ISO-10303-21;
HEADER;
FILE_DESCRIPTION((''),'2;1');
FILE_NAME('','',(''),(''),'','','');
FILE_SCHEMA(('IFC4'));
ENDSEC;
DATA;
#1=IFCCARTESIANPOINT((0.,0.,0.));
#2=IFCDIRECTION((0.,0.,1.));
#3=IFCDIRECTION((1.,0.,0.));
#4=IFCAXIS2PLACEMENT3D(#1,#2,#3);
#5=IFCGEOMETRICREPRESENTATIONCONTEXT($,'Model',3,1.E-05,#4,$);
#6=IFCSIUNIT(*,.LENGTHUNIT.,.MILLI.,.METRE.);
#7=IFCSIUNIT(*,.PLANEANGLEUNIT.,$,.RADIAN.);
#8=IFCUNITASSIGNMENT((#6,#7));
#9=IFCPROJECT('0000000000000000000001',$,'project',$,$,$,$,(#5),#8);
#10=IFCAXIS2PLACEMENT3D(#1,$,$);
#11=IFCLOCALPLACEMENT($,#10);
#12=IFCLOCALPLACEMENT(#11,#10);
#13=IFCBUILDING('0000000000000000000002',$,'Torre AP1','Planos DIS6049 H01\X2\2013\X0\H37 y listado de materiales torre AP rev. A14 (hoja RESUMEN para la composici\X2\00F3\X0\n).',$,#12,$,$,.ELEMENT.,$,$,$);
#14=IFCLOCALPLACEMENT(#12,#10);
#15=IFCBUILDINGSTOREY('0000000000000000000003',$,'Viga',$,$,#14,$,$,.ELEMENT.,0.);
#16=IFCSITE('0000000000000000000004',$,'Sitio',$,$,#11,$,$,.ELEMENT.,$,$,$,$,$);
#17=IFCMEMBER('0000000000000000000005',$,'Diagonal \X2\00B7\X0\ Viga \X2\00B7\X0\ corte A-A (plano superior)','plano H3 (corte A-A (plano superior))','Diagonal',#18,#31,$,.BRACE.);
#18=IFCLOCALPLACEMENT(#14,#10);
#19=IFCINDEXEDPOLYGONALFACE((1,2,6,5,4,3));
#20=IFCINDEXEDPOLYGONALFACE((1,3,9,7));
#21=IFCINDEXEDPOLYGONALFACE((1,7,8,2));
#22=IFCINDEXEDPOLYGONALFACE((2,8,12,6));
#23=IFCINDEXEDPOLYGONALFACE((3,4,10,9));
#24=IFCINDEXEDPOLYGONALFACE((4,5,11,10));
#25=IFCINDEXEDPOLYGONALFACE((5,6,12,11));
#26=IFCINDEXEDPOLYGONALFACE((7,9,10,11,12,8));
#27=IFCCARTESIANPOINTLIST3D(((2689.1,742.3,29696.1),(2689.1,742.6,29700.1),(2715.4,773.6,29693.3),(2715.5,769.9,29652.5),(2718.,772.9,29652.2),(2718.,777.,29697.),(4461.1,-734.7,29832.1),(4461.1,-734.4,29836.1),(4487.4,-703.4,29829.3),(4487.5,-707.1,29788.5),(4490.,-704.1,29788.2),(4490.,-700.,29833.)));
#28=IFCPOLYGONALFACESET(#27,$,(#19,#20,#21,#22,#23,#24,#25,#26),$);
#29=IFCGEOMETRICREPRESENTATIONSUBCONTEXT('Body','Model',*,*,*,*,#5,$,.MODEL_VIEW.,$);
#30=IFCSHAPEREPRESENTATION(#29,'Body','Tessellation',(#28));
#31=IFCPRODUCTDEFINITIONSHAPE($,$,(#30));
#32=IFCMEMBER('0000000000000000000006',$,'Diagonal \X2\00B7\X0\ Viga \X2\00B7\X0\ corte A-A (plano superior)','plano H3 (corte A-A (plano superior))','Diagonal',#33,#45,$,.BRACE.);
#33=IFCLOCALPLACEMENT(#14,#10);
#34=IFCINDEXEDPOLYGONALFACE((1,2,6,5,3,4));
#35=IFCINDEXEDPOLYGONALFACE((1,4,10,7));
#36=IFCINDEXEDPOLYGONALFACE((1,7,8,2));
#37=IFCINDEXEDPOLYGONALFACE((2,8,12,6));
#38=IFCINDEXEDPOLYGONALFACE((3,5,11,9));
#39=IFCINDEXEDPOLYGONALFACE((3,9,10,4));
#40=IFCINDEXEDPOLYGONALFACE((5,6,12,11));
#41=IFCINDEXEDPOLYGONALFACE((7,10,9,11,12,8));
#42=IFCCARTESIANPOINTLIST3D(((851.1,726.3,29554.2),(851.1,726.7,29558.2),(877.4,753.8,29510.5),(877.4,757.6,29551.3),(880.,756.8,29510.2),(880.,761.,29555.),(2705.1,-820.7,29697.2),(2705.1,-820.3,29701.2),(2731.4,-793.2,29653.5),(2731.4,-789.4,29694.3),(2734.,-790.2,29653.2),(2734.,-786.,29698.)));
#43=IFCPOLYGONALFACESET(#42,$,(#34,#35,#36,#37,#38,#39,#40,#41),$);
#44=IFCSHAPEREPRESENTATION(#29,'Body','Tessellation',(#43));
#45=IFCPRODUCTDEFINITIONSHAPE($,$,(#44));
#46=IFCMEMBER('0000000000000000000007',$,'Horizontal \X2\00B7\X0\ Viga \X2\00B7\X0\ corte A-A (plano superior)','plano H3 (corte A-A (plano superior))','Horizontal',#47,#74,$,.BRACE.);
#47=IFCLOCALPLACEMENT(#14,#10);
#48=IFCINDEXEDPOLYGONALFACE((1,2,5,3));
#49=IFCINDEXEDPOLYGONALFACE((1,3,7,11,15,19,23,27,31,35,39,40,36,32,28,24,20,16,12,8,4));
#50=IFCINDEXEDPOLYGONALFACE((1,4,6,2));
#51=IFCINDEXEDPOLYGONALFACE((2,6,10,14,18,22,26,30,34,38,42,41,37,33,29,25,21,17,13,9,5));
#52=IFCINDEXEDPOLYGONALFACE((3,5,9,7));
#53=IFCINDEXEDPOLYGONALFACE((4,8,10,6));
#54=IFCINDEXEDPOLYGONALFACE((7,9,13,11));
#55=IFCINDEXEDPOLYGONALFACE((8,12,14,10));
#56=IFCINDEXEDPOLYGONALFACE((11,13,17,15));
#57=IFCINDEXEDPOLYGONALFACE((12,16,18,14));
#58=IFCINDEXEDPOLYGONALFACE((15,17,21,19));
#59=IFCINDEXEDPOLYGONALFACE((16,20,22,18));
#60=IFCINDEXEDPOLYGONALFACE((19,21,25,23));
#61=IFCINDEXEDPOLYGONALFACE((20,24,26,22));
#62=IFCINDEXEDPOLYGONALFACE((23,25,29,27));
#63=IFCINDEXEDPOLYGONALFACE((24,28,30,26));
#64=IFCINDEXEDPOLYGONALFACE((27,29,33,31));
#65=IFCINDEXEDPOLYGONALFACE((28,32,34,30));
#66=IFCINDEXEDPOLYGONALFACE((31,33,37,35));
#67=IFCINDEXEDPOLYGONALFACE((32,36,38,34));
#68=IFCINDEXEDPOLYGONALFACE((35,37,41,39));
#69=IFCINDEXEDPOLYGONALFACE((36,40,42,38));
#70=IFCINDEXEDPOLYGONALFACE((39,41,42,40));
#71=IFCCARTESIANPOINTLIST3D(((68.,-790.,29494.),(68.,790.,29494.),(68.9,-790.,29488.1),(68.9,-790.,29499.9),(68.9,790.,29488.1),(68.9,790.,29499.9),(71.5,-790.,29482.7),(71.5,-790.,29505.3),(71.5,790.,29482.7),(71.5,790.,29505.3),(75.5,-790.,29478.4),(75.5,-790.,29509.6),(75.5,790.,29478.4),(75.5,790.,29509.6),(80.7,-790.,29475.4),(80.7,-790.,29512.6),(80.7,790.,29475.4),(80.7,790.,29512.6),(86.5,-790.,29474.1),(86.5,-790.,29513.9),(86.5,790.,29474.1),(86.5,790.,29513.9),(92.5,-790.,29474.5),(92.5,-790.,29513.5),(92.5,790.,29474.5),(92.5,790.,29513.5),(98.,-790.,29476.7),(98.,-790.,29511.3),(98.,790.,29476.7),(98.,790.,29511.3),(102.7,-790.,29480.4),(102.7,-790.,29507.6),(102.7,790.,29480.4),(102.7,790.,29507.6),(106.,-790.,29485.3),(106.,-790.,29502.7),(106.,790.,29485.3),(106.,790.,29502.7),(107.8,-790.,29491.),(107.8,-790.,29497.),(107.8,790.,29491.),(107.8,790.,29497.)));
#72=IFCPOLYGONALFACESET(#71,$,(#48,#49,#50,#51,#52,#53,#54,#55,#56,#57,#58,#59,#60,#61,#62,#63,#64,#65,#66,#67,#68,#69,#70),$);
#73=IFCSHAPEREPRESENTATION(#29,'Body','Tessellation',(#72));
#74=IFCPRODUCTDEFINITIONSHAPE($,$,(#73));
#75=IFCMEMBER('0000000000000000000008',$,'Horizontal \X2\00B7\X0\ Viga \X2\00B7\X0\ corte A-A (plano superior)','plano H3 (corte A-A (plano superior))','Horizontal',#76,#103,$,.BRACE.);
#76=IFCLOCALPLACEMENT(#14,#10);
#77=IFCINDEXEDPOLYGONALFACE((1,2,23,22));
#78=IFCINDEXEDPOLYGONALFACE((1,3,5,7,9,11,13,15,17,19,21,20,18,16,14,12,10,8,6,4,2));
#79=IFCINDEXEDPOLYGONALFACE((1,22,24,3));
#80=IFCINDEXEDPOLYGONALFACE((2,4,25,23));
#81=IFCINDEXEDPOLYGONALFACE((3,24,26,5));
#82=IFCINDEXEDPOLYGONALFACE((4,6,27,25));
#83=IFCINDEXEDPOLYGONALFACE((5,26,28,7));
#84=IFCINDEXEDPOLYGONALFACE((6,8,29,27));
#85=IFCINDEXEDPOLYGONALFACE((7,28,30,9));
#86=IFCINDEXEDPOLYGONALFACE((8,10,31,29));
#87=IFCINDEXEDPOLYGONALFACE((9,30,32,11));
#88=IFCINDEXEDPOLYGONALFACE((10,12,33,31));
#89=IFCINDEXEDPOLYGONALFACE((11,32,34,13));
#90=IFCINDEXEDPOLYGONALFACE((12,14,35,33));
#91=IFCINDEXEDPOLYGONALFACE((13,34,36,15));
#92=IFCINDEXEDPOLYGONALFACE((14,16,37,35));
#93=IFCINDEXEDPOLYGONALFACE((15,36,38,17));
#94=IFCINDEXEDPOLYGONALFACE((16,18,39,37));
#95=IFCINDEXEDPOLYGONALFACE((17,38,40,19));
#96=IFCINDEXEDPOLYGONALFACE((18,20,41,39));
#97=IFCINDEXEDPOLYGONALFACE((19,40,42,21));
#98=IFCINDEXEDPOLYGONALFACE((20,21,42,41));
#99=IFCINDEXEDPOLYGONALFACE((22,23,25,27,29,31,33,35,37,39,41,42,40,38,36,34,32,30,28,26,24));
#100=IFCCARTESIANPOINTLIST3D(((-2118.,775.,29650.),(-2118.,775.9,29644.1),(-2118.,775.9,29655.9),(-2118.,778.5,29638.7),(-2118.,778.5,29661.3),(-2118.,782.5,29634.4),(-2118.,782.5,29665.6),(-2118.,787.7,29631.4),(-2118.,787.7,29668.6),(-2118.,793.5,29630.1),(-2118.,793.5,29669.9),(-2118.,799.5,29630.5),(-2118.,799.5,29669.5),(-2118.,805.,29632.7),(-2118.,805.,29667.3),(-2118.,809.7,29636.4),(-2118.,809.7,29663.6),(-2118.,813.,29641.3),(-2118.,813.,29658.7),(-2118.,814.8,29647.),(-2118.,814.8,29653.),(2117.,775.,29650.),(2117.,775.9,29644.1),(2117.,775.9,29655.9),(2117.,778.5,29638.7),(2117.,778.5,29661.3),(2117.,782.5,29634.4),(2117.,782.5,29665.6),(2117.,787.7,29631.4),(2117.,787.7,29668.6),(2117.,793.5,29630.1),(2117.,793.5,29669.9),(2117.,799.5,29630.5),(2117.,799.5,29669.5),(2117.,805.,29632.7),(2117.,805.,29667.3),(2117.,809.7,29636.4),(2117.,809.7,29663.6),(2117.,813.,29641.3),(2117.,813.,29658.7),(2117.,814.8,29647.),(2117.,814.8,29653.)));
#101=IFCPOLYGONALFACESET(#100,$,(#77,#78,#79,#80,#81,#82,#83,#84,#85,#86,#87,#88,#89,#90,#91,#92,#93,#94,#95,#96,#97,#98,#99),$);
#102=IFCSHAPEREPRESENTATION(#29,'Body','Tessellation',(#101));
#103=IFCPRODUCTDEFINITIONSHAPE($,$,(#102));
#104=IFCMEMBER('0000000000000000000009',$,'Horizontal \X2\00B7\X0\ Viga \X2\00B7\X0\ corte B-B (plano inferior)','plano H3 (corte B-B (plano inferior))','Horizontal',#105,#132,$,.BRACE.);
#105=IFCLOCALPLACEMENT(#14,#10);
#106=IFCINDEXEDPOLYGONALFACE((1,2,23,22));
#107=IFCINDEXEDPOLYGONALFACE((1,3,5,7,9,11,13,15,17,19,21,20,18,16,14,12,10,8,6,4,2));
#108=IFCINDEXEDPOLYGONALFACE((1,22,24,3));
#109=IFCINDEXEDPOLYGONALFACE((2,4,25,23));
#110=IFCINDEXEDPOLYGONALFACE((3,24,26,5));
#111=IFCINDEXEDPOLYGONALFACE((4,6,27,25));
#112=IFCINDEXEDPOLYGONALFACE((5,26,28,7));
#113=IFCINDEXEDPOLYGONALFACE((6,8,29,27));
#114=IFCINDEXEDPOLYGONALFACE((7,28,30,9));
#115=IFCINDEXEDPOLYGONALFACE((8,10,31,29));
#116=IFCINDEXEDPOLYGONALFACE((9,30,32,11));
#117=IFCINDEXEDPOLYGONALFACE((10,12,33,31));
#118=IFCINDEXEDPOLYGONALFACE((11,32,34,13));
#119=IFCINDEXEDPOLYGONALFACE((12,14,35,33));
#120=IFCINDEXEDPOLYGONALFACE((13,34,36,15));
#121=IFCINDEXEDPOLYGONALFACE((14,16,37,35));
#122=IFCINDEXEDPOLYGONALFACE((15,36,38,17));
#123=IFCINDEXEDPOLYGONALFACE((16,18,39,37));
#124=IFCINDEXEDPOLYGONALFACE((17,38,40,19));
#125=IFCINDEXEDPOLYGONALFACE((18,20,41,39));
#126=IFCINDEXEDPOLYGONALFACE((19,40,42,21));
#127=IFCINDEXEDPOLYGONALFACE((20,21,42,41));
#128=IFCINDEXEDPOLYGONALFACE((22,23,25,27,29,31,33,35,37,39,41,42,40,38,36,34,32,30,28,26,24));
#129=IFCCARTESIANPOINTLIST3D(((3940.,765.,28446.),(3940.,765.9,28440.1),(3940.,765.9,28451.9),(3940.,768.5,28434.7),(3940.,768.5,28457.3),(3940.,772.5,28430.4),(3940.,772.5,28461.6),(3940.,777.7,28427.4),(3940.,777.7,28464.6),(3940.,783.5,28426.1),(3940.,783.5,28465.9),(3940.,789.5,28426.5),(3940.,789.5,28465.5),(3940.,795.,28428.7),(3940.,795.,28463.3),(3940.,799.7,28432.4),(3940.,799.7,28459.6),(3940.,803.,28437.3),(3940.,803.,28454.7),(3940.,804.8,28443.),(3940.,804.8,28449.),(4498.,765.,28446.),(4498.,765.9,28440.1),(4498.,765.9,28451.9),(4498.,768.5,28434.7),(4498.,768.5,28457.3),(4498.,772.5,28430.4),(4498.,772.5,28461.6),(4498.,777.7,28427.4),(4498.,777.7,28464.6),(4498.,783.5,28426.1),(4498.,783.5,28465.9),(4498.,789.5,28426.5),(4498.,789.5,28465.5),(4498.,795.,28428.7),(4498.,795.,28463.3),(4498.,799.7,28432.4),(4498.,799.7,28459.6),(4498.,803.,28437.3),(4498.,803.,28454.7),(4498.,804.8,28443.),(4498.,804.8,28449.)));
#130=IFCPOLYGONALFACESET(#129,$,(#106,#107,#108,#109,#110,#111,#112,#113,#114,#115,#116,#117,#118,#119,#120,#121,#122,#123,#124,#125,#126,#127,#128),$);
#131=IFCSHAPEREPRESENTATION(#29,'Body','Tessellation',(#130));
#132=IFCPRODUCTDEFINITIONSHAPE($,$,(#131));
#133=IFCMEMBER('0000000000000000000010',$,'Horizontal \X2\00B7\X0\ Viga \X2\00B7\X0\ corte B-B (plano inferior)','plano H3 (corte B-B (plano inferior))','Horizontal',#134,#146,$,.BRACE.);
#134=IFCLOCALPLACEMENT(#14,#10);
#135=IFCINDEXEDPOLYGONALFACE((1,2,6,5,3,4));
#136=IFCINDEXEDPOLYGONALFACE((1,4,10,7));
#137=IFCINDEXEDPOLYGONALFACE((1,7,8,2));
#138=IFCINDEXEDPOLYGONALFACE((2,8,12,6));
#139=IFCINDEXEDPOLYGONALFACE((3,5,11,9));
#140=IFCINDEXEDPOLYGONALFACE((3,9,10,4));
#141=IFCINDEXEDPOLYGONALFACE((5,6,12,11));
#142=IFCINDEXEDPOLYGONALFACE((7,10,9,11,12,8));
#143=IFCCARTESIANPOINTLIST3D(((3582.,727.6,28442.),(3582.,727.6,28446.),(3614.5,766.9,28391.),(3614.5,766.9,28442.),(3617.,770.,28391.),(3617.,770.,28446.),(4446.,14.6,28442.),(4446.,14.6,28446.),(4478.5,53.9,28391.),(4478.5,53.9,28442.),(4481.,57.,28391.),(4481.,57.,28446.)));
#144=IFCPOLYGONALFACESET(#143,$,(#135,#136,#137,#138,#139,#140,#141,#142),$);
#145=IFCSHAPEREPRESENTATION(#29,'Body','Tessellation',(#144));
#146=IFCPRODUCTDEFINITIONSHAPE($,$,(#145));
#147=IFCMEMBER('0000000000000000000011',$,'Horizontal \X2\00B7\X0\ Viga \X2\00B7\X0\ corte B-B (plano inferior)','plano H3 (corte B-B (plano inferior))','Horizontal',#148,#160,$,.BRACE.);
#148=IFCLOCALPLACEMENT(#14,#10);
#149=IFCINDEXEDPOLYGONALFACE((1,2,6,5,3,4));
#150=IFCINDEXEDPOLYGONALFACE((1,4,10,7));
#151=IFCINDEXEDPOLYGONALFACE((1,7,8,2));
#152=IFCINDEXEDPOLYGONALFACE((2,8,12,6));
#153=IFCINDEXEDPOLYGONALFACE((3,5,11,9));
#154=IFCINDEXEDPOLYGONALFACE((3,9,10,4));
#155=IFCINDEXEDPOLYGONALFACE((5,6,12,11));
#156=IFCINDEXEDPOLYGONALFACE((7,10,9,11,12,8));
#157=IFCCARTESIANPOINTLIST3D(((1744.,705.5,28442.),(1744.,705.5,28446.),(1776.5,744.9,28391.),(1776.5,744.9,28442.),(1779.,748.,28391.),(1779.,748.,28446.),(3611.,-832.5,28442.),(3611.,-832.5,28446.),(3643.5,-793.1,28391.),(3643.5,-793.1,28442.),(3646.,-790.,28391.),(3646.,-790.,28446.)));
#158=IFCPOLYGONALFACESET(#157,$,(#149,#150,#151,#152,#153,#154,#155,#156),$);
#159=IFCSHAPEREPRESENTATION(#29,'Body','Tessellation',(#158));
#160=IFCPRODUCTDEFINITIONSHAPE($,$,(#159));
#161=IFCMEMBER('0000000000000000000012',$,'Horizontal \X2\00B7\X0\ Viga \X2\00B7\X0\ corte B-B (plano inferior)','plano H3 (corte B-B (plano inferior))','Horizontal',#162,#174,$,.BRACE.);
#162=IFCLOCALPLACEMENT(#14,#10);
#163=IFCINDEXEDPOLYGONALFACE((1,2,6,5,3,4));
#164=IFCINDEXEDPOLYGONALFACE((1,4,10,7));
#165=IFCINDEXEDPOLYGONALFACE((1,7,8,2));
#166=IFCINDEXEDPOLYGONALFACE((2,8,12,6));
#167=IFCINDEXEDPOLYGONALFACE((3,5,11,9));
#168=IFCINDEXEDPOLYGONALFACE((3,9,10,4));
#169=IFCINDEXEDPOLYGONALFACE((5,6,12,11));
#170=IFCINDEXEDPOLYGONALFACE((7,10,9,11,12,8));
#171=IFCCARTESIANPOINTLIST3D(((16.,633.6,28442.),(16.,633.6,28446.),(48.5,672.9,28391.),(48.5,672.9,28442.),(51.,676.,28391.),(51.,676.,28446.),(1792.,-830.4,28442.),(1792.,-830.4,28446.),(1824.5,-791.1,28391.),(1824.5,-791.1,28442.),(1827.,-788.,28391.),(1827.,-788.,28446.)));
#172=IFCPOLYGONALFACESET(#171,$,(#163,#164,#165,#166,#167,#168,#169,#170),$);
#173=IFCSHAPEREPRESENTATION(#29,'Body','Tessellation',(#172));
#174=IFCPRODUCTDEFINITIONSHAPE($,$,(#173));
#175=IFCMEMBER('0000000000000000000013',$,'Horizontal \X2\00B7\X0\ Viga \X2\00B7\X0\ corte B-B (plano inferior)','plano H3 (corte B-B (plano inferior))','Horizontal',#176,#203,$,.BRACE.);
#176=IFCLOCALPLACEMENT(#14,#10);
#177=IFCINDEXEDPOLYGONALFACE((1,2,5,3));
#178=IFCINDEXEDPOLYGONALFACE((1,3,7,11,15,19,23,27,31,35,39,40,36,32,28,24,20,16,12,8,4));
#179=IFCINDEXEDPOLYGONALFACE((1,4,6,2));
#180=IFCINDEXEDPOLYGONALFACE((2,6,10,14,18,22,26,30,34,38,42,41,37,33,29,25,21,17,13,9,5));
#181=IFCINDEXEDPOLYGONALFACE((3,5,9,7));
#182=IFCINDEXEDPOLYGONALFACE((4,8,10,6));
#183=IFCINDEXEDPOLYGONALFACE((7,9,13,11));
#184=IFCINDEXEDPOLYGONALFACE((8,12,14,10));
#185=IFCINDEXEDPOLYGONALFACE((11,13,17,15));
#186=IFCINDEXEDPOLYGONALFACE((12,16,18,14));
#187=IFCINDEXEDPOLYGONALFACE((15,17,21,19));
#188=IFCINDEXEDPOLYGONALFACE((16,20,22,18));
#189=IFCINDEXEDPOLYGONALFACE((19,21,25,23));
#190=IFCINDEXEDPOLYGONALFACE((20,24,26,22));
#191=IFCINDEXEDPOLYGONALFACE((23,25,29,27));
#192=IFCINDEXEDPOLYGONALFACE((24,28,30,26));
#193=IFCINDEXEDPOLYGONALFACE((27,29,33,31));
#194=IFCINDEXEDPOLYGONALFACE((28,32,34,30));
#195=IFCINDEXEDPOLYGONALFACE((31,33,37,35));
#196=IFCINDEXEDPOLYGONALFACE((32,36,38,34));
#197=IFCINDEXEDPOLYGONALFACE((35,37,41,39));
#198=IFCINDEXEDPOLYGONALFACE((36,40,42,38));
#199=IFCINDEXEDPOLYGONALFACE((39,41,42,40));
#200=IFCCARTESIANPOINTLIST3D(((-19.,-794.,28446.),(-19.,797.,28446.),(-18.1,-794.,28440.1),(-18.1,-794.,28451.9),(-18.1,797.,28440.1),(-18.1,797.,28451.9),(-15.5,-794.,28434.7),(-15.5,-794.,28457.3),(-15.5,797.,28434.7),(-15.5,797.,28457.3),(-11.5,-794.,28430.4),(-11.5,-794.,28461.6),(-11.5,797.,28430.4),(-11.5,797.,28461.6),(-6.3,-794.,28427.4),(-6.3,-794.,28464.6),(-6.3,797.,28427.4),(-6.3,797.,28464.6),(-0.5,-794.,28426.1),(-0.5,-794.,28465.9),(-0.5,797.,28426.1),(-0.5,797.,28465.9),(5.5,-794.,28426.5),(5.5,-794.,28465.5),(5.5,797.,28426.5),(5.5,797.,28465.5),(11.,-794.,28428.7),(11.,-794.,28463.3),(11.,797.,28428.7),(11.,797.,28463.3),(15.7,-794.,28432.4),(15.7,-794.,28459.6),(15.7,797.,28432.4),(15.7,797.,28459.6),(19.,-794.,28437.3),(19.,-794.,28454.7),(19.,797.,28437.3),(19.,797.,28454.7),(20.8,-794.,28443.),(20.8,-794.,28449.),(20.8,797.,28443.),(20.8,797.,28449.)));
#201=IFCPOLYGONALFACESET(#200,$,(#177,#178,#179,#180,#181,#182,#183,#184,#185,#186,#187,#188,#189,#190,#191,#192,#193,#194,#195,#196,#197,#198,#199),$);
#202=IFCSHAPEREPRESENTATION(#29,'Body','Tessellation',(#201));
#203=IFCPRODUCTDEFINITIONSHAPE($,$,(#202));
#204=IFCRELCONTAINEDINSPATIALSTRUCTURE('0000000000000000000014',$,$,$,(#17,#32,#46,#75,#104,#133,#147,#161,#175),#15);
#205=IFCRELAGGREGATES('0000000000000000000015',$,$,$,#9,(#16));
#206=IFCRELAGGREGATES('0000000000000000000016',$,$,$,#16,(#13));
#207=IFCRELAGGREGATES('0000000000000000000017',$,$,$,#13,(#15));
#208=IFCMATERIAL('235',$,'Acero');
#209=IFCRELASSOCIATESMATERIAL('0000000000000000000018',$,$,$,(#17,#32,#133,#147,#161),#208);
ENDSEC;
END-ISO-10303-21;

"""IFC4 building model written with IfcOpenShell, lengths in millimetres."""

from ifc_helpers import new_model, si_unit, frame, frame_2d, origin, origin_with_axes, place, context, subcontext, project, spatial, circle, l_section, extrude, material, element, save


model = new_model("IFC4")

# Units and contexts
model_context = context("Model", 3, precision=1e-05, world=origin_with_axes())
body_context = subcontext(model_context, "Body", "Model", "MODEL_VIEW")
ifc_project = project(units=[si_unit("LENGTHUNIT", "METRE", prefix="MILLI"), si_unit("PLANEANGLEUNIT", "RADIAN")], contexts=[model_context])

# Site, building, storey
site_placement = place(None, origin())
site = spatial("IfcSite", under=ifc_project, at=site_placement, Name="Sitio", CompositionType="ELEMENT")
building_placement = place(site_placement, origin())
building = spatial("IfcBuilding", under=site, at=building_placement, Name="Torre AP1", Description="Planos DIS6049 H01–H37 y listado de materiales torre AP rev. A14 (hoja RESUMEN para la composición).", CompositionType="ELEMENT")
storey_placement = place(building_placement, origin())
storey = spatial("IfcBuildingStorey", under=building, at=storey_placement, Name="Viga", CompositionType="ELEMENT", Elevation=0.0)

# Members
ifc_material = material(Name="235", Category="Acero")
member_1_placement = place(storey_placement, frame((2718.0, 777.0, 29697.0), z_axis=(0.766819, -0.63916, 0.058853), x_axis=(-0.641863, -0.763726, 0.06881)))
element("IfcMember", 1, at=member_1_placement, inside=storey, material=ifc_material, Name="Diagonal · Viga · corte A-A (plano superior)", Description="plano H3 (corte A-A (plano superior))", ObjectType="Diagonal", PredefinedType="BRACE", context=body_context, shape_type="SweptSolid", body=[
    extrude(l_section(Depth=45.0, Width=45.0, Thickness=4.0, at=frame_2d((22.5, 22.5))), None, (0.0, 0.0, 1.0), 2310.8),
])
member_2_placement = place(storey_placement, frame((880.0, 761.0, 29555.0), z_axis=(0.766471, -0.639553, 0.059118), x_axis=(-0.642279, -0.763125, 0.071545)))
element("IfcMember", 2, at=member_2_placement, inside=storey, material=ifc_material, Name="Diagonal · Viga · corte A-A (plano superior)", Description="plano H3 (corte A-A (plano superior))", ObjectType="Diagonal", PredefinedType="BRACE", context=body_context, shape_type="SweptSolid", body=[
    extrude(l_section(Depth=45.0, Width=45.0, Thickness=4.0, at=frame_2d((22.5, 22.5))), None, (0.0, 0.0, 1.0), 2418.9),
])
member_3_placement = place(storey_placement, frame((88.0, 790.0, 29494.0), z_axis=(0.0, -1.0, 0.0), x_axis=(-1.0, 0.0, 0.0)))
element("IfcMember", 3, at=member_3_placement, inside=storey, Name="Horizontal · Viga · corte A-A (plano superior)", Description="plano H3 (corte A-A (plano superior))", ObjectType="Horizontal", PredefinedType="BRACE", context=body_context, shape_type="SweptSolid", body=[
    extrude(circle(Radius=20.0), None, (0.0, 0.0, 1.0), 1580.0),
])
member_4_placement = place(storey_placement, frame((2117.0, 795.0, 29650.0), z_axis=(-1.0, 0.0, 0.0), x_axis=(0.0, -1.0, 0.0)))
element("IfcMember", 4, at=member_4_placement, inside=storey, Name="Horizontal · Viga · corte A-A (plano superior)", Description="plano H3 (corte A-A (plano superior))", ObjectType="Horizontal", PredefinedType="BRACE", context=body_context, shape_type="SweptSolid", body=[
    extrude(circle(Radius=20.0), None, (0.0, 0.0, 1.0), 4235.0),
])
member_5_placement = place(storey_placement, frame((3940.0, 785.0, 28446.0), z_axis=(1.0, 0.0, 0.0), x_axis=(0.0, -1.0, 0.0)))
element("IfcMember", 5, at=member_5_placement, inside=storey, Name="Horizontal · Viga · corte B-B (plano inferior)", Description="plano H3 (corte B-B (plano inferior))", ObjectType="Horizontal", PredefinedType="BRACE", context=body_context, shape_type="SweptSolid", body=[
    extrude(circle(Radius=20.0), None, (0.0, 0.0, 1.0), 558.0),
])
member_6_placement = place(storey_placement, frame((3617.0, 770.0, 28446.0), z_axis=(0.771286, -0.636489, 0.0), x_axis=(-0.636489, -0.771286, 0.0)))
element("IfcMember", 6, at=member_6_placement, inside=storey, material=ifc_material, Name="Horizontal · Viga · corte B-B (plano inferior)", Description="plano H3 (corte B-B (plano inferior))", ObjectType="Horizontal", PredefinedType="BRACE", context=body_context, shape_type="SweptSolid", body=[
    extrude(l_section(Depth=55.0, Width=55.0, Thickness=4.0, at=frame_2d((27.5, 27.5))), None, (0.0, 0.0, 1.0), 1120.2),
])
member_7_placement = place(storey_placement, frame((1779.0, 748.0, 28446.0), z_axis=(0.771835, -0.635823, 0.0), x_axis=(-0.635823, -0.771835, 0.0)))
element("IfcMember", 7, at=member_7_placement, inside=storey, material=ifc_material, Name="Horizontal · Viga · corte B-B (plano inferior)", Description="plano H3 (corte B-B (plano inferior))", ObjectType="Horizontal", PredefinedType="BRACE", context=body_context, shape_type="SweptSolid", body=[
    extrude(l_section(Depth=55.0, Width=55.0, Thickness=4.0, at=frame_2d((27.5, 27.5))), None, (0.0, 0.0, 1.0), 2418.9),
])
member_8_placement = place(storey_placement, frame((51.0, 676.0, 28446.0), z_axis=(0.771629, -0.636073, 0.0), x_axis=(-0.636073, -0.771629, 0.0)))
element("IfcMember", 8, at=member_8_placement, inside=storey, material=ifc_material, Name="Horizontal · Viga · corte B-B (plano inferior)", Description="plano H3 (corte B-B (plano inferior))", ObjectType="Horizontal", PredefinedType="BRACE", context=body_context, shape_type="SweptSolid", body=[
    extrude(l_section(Depth=55.0, Width=55.0, Thickness=4.0, at=frame_2d((27.5, 27.5))), None, (0.0, 0.0, 1.0), 2301.6),
])
member_9_placement = place(storey_placement, frame((1.0, 797.0, 28446.0), z_axis=(0.0, -1.0, 0.0), x_axis=(-1.0, 0.0, 0.0)))
element("IfcMember", 9, at=member_9_placement, inside=storey, Name="Horizontal · Viga · corte B-B (plano inferior)", Description="plano H3 (corte B-B (plano inferior))", ObjectType="Horizontal", PredefinedType="BRACE", context=body_context, shape_type="SweptSolid", body=[
    extrude(circle(Radius=20.0), None, (0.0, 0.0, 1.0), 1591.0),
])

save(model, "model.ifc")
